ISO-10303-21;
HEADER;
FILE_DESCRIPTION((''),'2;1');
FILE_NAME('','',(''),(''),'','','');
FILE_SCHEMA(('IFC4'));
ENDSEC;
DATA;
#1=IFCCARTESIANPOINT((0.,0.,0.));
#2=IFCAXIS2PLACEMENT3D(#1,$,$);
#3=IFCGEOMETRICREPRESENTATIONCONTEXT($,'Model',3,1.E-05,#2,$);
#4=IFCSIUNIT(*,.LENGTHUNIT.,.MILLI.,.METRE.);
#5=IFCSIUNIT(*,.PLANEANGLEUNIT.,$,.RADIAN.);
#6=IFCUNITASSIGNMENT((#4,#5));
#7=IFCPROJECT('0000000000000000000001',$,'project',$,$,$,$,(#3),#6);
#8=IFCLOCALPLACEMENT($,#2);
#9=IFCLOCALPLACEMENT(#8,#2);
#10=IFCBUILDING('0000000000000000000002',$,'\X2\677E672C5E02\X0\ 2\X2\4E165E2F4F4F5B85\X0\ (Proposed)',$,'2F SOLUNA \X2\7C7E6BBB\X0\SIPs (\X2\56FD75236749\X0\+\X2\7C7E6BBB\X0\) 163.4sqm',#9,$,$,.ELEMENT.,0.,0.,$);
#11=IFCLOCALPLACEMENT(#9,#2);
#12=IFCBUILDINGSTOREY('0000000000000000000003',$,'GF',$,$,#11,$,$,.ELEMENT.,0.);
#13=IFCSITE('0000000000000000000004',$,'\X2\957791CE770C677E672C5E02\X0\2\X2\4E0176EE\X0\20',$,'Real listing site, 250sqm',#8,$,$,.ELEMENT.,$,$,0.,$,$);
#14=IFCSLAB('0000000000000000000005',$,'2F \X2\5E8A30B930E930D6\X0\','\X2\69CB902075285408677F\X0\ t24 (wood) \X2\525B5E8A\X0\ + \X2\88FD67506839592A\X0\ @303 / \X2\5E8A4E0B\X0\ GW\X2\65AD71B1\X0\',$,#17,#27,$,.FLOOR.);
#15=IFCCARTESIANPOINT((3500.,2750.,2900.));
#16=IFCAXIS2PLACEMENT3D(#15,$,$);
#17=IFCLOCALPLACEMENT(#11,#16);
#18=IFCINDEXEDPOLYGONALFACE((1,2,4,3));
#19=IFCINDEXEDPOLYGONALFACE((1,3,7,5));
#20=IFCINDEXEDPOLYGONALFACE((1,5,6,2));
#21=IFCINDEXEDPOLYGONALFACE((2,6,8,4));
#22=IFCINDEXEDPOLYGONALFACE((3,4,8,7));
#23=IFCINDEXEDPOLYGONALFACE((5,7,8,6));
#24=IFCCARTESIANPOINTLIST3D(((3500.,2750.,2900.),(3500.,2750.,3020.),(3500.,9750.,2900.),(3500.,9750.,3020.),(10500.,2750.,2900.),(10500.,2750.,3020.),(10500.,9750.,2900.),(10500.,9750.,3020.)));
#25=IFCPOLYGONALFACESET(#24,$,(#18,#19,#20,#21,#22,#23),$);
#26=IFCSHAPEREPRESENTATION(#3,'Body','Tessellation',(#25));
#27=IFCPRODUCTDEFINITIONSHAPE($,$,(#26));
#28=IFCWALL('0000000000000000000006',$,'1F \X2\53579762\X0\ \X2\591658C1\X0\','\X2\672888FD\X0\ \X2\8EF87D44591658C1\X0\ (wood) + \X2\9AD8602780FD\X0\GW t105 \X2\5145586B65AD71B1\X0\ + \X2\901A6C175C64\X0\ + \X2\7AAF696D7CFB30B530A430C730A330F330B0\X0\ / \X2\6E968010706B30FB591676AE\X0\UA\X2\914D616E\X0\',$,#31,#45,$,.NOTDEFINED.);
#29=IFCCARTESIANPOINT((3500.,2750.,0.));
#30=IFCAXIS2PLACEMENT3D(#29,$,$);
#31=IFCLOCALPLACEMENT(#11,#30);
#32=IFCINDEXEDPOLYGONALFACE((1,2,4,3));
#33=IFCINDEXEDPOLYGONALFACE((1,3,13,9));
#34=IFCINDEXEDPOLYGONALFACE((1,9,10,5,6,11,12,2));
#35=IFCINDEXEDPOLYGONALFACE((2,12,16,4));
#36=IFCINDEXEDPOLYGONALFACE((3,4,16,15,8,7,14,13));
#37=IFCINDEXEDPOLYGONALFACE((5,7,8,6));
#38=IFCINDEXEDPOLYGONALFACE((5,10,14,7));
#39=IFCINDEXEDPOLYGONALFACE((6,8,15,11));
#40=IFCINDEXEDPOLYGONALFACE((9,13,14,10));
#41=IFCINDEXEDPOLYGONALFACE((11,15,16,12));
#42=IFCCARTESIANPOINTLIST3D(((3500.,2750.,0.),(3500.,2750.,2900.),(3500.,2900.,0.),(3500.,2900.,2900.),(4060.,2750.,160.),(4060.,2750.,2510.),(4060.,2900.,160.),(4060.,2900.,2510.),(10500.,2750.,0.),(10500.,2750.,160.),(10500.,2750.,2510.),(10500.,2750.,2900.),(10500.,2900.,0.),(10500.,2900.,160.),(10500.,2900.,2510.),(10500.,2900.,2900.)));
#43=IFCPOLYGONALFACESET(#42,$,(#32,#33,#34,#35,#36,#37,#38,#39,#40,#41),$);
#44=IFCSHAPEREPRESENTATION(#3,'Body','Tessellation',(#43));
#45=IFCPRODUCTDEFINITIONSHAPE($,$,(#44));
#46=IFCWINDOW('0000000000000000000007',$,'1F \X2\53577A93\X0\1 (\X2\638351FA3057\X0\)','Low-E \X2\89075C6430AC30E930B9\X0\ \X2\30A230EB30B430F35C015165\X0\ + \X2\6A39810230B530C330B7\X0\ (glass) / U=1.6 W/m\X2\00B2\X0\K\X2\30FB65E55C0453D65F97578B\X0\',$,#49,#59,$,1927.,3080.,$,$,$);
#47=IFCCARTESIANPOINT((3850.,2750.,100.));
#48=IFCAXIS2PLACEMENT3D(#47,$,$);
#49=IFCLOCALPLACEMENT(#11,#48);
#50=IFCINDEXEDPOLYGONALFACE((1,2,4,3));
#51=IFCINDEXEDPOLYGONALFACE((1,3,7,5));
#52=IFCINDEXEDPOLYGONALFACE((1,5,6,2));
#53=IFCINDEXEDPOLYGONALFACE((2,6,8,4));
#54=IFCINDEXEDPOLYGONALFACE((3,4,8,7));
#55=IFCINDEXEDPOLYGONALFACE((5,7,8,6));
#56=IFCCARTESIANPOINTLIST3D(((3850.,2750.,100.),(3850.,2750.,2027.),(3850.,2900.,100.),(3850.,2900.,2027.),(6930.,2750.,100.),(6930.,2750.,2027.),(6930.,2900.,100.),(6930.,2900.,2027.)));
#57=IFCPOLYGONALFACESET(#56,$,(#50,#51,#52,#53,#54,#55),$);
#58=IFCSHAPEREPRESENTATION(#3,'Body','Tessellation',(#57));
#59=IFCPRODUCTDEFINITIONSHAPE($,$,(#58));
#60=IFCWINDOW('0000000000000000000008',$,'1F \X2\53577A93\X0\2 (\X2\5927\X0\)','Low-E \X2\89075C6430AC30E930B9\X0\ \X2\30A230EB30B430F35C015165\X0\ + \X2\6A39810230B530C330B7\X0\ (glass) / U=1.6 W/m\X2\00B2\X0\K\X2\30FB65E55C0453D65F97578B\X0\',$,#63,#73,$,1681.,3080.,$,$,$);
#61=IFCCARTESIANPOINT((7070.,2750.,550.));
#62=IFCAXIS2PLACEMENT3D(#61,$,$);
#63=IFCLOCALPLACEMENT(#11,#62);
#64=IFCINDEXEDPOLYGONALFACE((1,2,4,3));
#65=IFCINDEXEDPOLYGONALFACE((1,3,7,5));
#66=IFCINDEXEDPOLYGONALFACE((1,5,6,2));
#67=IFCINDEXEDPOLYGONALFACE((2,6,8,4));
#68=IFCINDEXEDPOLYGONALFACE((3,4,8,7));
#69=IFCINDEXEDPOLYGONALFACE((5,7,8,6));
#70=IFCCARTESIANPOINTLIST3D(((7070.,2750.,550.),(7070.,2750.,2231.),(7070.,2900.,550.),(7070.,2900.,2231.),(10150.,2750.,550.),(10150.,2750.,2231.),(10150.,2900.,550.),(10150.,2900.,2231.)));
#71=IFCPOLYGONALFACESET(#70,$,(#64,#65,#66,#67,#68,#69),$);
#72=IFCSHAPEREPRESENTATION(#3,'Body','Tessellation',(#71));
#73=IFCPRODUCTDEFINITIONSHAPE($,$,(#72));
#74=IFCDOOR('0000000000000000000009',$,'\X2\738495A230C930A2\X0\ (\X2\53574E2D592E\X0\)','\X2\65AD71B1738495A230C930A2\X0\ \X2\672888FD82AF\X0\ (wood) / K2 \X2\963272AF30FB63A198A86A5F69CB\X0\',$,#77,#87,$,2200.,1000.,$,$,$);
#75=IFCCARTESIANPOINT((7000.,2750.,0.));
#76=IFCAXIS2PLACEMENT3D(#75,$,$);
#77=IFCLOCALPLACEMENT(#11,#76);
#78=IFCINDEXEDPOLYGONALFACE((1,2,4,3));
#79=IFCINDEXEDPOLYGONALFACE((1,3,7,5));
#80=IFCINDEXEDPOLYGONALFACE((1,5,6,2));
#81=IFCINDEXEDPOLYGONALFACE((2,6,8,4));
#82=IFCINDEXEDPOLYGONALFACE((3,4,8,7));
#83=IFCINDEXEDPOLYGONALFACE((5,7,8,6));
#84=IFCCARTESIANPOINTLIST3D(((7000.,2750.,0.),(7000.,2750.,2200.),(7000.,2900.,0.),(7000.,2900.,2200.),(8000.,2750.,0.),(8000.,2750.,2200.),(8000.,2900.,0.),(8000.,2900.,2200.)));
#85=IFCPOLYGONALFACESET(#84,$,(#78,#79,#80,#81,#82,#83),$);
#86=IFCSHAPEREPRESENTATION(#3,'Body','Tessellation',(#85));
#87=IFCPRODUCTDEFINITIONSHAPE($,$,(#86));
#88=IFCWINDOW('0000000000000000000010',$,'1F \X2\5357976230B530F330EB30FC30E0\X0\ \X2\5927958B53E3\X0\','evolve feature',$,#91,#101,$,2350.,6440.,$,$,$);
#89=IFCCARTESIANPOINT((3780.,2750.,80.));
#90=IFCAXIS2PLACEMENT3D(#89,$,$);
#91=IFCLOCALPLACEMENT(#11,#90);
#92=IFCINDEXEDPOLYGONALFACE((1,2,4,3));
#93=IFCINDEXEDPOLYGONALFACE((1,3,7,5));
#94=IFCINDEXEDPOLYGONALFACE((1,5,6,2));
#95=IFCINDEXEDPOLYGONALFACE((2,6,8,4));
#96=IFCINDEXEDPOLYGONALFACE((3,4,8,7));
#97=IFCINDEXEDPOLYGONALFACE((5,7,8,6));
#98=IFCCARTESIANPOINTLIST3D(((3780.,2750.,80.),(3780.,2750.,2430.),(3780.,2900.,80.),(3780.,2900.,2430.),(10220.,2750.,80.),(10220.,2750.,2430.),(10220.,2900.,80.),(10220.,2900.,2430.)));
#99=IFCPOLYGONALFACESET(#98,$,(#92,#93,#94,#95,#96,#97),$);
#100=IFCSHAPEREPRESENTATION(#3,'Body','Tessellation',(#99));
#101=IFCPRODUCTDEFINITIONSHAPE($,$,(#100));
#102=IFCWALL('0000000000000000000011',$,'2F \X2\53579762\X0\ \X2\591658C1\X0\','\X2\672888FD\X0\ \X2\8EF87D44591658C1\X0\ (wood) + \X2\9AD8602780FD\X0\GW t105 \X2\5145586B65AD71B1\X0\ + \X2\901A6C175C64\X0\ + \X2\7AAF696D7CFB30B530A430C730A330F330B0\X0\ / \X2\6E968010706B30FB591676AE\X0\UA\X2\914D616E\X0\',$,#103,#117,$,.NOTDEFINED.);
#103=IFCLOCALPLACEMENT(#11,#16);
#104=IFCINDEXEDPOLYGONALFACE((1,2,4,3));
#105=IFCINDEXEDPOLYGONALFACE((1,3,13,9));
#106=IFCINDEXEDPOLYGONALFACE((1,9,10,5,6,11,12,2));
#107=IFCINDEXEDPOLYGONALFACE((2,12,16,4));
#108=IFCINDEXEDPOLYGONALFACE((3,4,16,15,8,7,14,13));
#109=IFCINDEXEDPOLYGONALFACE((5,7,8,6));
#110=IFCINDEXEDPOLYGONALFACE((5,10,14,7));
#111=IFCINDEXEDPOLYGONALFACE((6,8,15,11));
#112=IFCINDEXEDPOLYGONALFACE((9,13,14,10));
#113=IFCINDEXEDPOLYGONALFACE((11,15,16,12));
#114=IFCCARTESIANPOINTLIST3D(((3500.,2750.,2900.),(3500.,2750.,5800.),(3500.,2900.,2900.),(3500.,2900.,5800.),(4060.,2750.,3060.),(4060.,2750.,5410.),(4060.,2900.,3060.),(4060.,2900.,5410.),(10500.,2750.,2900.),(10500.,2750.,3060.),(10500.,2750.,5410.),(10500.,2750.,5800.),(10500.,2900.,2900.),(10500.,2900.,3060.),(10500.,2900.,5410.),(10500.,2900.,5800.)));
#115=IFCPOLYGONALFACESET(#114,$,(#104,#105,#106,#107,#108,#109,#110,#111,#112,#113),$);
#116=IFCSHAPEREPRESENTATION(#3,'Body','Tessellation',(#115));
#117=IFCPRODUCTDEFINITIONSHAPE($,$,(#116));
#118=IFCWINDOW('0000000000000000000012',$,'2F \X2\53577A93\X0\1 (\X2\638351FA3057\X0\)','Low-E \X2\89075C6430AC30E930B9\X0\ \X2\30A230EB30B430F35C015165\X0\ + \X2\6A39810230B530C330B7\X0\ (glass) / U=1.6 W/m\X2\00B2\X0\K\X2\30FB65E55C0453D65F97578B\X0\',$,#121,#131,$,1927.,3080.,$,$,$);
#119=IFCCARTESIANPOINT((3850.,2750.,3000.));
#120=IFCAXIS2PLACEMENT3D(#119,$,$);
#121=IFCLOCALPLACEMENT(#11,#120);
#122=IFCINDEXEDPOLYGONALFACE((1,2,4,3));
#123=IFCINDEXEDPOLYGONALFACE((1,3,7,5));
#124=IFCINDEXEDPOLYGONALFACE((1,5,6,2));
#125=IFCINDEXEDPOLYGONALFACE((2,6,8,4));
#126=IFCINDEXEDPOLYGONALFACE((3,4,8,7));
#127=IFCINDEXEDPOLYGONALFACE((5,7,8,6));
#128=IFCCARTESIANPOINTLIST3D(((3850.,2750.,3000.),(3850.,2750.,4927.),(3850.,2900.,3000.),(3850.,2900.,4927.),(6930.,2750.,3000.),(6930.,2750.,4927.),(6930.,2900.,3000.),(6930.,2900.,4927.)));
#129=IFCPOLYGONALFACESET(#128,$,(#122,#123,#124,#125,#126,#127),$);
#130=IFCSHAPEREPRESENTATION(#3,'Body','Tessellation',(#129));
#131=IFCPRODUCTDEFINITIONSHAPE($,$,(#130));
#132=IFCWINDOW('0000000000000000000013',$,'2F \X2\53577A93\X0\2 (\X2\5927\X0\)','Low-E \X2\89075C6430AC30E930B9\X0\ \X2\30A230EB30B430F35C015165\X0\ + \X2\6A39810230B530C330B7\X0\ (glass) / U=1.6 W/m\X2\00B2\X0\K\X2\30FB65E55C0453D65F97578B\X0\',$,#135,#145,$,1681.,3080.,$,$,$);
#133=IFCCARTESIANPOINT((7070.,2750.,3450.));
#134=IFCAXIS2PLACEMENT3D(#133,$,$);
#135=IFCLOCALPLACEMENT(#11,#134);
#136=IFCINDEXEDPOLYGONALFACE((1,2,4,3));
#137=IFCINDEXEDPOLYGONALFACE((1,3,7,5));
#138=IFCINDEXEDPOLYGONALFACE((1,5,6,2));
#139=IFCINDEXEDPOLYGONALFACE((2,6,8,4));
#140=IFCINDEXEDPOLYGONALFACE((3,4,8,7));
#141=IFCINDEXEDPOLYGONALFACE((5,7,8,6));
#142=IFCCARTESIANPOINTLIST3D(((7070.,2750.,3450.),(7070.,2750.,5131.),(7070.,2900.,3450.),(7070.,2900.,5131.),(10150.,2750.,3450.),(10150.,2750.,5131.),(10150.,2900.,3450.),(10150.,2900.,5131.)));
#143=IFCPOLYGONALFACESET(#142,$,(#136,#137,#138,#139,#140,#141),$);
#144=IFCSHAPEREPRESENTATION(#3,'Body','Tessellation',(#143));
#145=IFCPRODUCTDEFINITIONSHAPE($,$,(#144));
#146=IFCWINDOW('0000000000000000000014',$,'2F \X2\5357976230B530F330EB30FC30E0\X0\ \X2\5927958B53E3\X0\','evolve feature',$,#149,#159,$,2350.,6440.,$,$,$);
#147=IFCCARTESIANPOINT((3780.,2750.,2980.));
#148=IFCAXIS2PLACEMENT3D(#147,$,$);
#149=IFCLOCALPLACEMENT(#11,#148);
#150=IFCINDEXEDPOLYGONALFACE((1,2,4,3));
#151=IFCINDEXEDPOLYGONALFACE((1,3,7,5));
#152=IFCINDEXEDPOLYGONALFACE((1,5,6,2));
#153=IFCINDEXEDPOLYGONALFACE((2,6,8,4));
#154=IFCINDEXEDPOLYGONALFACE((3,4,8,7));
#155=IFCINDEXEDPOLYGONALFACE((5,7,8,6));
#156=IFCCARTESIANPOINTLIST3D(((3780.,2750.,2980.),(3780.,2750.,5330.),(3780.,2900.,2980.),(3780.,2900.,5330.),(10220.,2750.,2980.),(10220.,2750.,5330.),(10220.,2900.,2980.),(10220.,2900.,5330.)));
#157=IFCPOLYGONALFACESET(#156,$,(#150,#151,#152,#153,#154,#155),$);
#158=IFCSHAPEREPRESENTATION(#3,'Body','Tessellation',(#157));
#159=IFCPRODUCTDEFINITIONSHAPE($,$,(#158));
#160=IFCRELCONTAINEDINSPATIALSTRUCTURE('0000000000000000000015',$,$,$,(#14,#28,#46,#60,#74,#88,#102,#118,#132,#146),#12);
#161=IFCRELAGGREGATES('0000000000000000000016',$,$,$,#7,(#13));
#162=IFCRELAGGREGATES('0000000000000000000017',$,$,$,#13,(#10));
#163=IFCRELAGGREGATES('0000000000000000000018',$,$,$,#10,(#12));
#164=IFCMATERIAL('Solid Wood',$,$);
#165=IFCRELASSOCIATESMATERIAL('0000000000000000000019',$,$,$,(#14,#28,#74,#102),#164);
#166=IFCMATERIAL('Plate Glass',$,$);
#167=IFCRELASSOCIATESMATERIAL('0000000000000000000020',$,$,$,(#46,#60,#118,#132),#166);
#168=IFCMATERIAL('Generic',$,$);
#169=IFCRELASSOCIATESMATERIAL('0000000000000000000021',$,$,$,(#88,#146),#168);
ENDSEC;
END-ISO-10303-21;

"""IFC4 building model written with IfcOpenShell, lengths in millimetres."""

from ifc_helpers import new_model, si_unit, frame, frame_2d, origin, place, context, project, spatial, rectangle, extrude, material, element, fill, save


model = new_model("IFC4")

# Units and contexts
model_context = context("Model", 3, precision=1e-05, world=origin())
ifc_project = project(units=[si_unit("LENGTHUNIT", "METRE", prefix="MILLI"), si_unit("PLANEANGLEUNIT", "RADIAN")], contexts=[model_context])

# Site, building, storey
site_placement = place(None, origin())
site = spatial("IfcSite", under=ifc_project, at=site_placement, Name="長野県松本市2丁目20", ObjectType="Real listing site, 250sqm", CompositionType="ELEMENT", RefElevation=0.0)
building_placement = place(site_placement, origin())
building = spatial("IfcBuilding", under=site, at=building_placement, Name="松本市 2世帯住宅 (Proposed)", ObjectType="2F SOLUNA 籾殻SIPs (国産杉+籾殻) 163.4sqm", CompositionType="ELEMENT", ElevationOfRefHeight=0.0, ElevationOfTerrain=0.0)
storey_placement = place(building_placement, origin())
storey = spatial("IfcBuildingStorey", under=building, at=storey_placement, Name="GF", CompositionType="ELEMENT", Elevation=0.0)

# Slab
ifc_material_1 = material(Name="Solid Wood")
slab_1_placement = place(storey_placement, frame((3500.0, 2750.0, 2900.0)))
element("IfcSlab", 1, at=slab_1_placement, inside=storey, material=ifc_material_1, Name="2F 床スラブ", Description="構造用合板 t24 (wood) 剛床 + 製材根太 @303 / 床下 GW断熱", PredefinedType="FLOOR", context=model_context, shape_type="SweptSolid", body=[
    extrude(rectangle(XDim=7000.0, YDim=7000.0, at=frame_2d((3500.0, 3500.0))), frame((3500.0, 2750.0, 2900.0)), (0.0, 0.0, 1.0), 120.0),
])
ifc_material_2 = material(Name="Generic")

# Wall, openings, windows, door
wall_1_placement = place(storey_placement, frame((3500.0, 2750.0, 0.0)))
wall_1 = element("IfcWall", 2, at=wall_1_placement, inside=storey, material=ifc_material_1, Name="1F 南面 外壁", Description="木製 軸組外壁 (wood) + 高性能GW t105 充填断熱 + 通気層 + 窯業系サイディング / 準耐火・外皮UA配慮", PredefinedType="NOTDEFINED", context=model_context, shape_type="SweptSolid", body=[
    extrude(rectangle(XDim=7000.0, YDim=150.0, at=frame_2d((3500.0, 75.0))), frame((3500.0, 2750.0, 0.0)), (0.0, 0.0, 1.0), 2900.0),
])
opening_1_placement = place(storey_placement, frame((3850.0, 2750.0, 100.0)))
opening_1 = element("IfcOpeningElement", 3, at=opening_1_placement, cuts=wall_1, PredefinedType="NOTDEFINED", context=model_context, shape_type="SweptSolid", body=[
    extrude(rectangle(XDim=3080.0, YDim=150.0, at=frame_2d((1540.0, 75.0))), frame((3850.0, 2750.0, 100.0)), (0.0, 0.0, 1.0), 1927.0),
])
opening_2_placement = place(storey_placement, frame((7070.0, 2750.0, 550.0)))
opening_2 = element("IfcOpeningElement", 4, at=opening_2_placement, cuts=wall_1, PredefinedType="NOTDEFINED", context=model_context, shape_type="SweptSolid", body=[
    extrude(rectangle(XDim=3080.0, YDim=150.0, at=frame_2d((1540.0, 75.0))), frame((7070.0, 2750.0, 550.0)), (0.0, 0.0, 1.0), 1681.0),
])
opening_3_placement = place(storey_placement, frame((7000.0, 2750.0, 0.0)))
opening_3 = element("IfcOpeningElement", 5, at=opening_3_placement, cuts=wall_1, PredefinedType="NOTDEFINED", context=model_context, shape_type="SweptSolid", body=[
    extrude(rectangle(XDim=1000.0, YDim=150.0, at=frame_2d((500.0, 75.0))), frame((7000.0, 2750.0, 0.0)), (0.0, 0.0, 1.0), 2200.0),
])
opening_4_placement = place(storey_placement, frame((3780.0, 2750.0, 80.0)))
opening_4 = element("IfcOpeningElement", 6, at=opening_4_placement, cuts=wall_1, PredefinedType="NOTDEFINED", context=model_context, shape_type="SweptSolid", body=[
    extrude(rectangle(XDim=6440.0, YDim=150.0, at=frame_2d((3220.0, 75.0))), frame((3780.0, 2750.0, 80.0)), (0.0, 0.0, 1.0), 2350.0),
])
ifc_material_3 = material(Name="Plate Glass")
window_1_placement = place(storey_placement, frame((3850.0, 2750.0, 100.0)))
window_1 = element("IfcWindow", 7, at=window_1_placement, inside=storey, material=ifc_material_3, Name="1F 南窓1 (掃出し)", Description="Low-E 複層ガラス アルゴン封入 + 樹脂サッシ (glass) / U=1.6 W/m²K・日射取得型", OverallHeight=1927.0, OverallWidth=3080.0, context=model_context, shape_type="SweptSolid", body=[
    extrude(rectangle(XDim=3080.0, YDim=150.0, at=frame_2d((1540.0, 75.0))), frame((3850.0, 2750.0, 100.0)), (0.0, 0.0, 1.0), 1927.0),
])
fill(opening_1, window_1)
window_2_placement = place(storey_placement, frame((7070.0, 2750.0, 550.0)))
window_2 = element("IfcWindow", 8, at=window_2_placement, inside=storey, material=ifc_material_3, Name="1F 南窓2 (大)", Description="Low-E 複層ガラス アルゴン封入 + 樹脂サッシ (glass) / U=1.6 W/m²K・日射取得型", OverallHeight=1681.0, OverallWidth=3080.0, context=model_context, shape_type="SweptSolid", body=[
    extrude(rectangle(XDim=3080.0, YDim=150.0, at=frame_2d((1540.0, 75.0))), frame((7070.0, 2750.0, 550.0)), (0.0, 0.0, 1.0), 1681.0),
])
fill(opening_2, window_2)
door_placement = place(storey_placement, frame((7000.0, 2750.0, 0.0)))
door = element("IfcDoor", 9, at=door_placement, inside=storey, material=ifc_material_1, Name="玄関ドア (南中央)", Description="断熱玄関ドア 木製芯 (wood) / K2 防犯・採風機構", OverallHeight=2200.0, OverallWidth=1000.0, context=model_context, shape_type="SweptSolid", body=[
    extrude(rectangle(XDim=1000.0, YDim=150.0, at=frame_2d((500.0, 75.0))), frame((7000.0, 2750.0, 0.0)), (0.0, 0.0, 1.0), 2200.0),
])
fill(opening_3, door)
window_3_placement = place(storey_placement, frame((3780.0, 2750.0, 80.0)))
window_3 = element("IfcWindow", 10, at=window_3_placement, inside=storey, material=ifc_material_2, Name="1F 南面サンルーム 大開口", Description="evolve feature", OverallHeight=2350.0, OverallWidth=6440.0, context=model_context, shape_type="SweptSolid", body=[
    extrude(rectangle(XDim=6440.0, YDim=150.0, at=frame_2d((3220.0, 75.0))), frame((3780.0, 2750.0, 80.0)), (0.0, 0.0, 1.0), 2350.0),
])
fill(opening_4, window_3)

# Wall, openings, windows
wall_2_placement = place(storey_placement, frame((3500.0, 2750.0, 2900.0)))
wall_2 = element("IfcWall", 11, at=wall_2_placement, inside=storey, material=ifc_material_1, Name="2F 南面 外壁", Description="木製 軸組外壁 (wood) + 高性能GW t105 充填断熱 + 通気層 + 窯業系サイディング / 準耐火・外皮UA配慮", PredefinedType="NOTDEFINED", context=model_context, shape_type="SweptSolid", body=[
    extrude(rectangle(XDim=7000.0, YDim=150.0, at=frame_2d((3500.0, 75.0))), frame((3500.0, 2750.0, 2900.0)), (0.0, 0.0, 1.0), 2900.0),
])
opening_5_placement = place(storey_placement, frame((3850.0, 2750.0, 3000.0)))
opening_5 = element("IfcOpeningElement", 12, at=opening_5_placement, cuts=wall_2, PredefinedType="NOTDEFINED", context=model_context, shape_type="SweptSolid", body=[
    extrude(rectangle(XDim=3080.0, YDim=150.0, at=frame_2d((1540.0, 75.0))), frame((3850.0, 2750.0, 3000.0)), (0.0, 0.0, 1.0), 1927.0),
])
opening_6_placement = place(storey_placement, frame((7070.0, 2750.0, 3450.0)))
opening_6 = element("IfcOpeningElement", 13, at=opening_6_placement, cuts=wall_2, PredefinedType="NOTDEFINED", context=model_context, shape_type="SweptSolid", body=[
    extrude(rectangle(XDim=3080.0, YDim=150.0, at=frame_2d((1540.0, 75.0))), frame((7070.0, 2750.0, 3450.0)), (0.0, 0.0, 1.0), 1681.0),
])
opening_7_placement = place(storey_placement, frame((3780.0, 2750.0, 2980.0)))
opening_7 = element("IfcOpeningElement", 14, at=opening_7_placement, cuts=wall_2, PredefinedType="NOTDEFINED", context=model_context, shape_type="SweptSolid", body=[
    extrude(rectangle(XDim=6440.0, YDim=150.0, at=frame_2d((3220.0, 75.0))), frame((3780.0, 2750.0, 2980.0)), (0.0, 0.0, 1.0), 2350.0),
])
window_4_placement = place(storey_placement, frame((3850.0, 2750.0, 3000.0)))
window_4 = element("IfcWindow", 15, at=window_4_placement, inside=storey, material=ifc_material_3, Name="2F 南窓1 (掃出し)", Description="Low-E 複層ガラス アルゴン封入 + 樹脂サッシ (glass) / U=1.6 W/m²K・日射取得型", OverallHeight=1927.0, OverallWidth=3080.0, context=model_context, shape_type="SweptSolid", body=[
    extrude(rectangle(XDim=3080.0, YDim=150.0, at=frame_2d((1540.0, 75.0))), frame((3850.0, 2750.0, 3000.0)), (0.0, 0.0, 1.0), 1927.0),
])
fill(opening_5, window_4)
window_5_placement = place(storey_placement, frame((7070.0, 2750.0, 3450.0)))
window_5 = element("IfcWindow", 16, at=window_5_placement, inside=storey, material=ifc_material_3, Name="2F 南窓2 (大)", Description="Low-E 複層ガラス アルゴン封入 + 樹脂サッシ (glass) / U=1.6 W/m²K・日射取得型", OverallHeight=1681.0, OverallWidth=3080.0, context=model_context, shape_type="SweptSolid", body=[
    extrude(rectangle(XDim=3080.0, YDim=150.0, at=frame_2d((1540.0, 75.0))), frame((7070.0, 2750.0, 3450.0)), (0.0, 0.0, 1.0), 1681.0),
])
fill(opening_6, window_5)
window_6_placement = place(storey_placement, frame((3780.0, 2750.0, 2980.0)))
window_6 = element("IfcWindow", 17, at=window_6_placement, inside=storey, material=ifc_material_2, Name="2F 南面サンルーム 大開口", Description="evolve feature", OverallHeight=2350.0, OverallWidth=6440.0, context=model_context, shape_type="SweptSolid", body=[
    extrude(rectangle(XDim=6440.0, YDim=150.0, at=frame_2d((3220.0, 75.0))), frame((3780.0, 2750.0, 2980.0)), (0.0, 0.0, 1.0), 2350.0),
])
fill(opening_7, window_6)

save(model, "model.ifc")
